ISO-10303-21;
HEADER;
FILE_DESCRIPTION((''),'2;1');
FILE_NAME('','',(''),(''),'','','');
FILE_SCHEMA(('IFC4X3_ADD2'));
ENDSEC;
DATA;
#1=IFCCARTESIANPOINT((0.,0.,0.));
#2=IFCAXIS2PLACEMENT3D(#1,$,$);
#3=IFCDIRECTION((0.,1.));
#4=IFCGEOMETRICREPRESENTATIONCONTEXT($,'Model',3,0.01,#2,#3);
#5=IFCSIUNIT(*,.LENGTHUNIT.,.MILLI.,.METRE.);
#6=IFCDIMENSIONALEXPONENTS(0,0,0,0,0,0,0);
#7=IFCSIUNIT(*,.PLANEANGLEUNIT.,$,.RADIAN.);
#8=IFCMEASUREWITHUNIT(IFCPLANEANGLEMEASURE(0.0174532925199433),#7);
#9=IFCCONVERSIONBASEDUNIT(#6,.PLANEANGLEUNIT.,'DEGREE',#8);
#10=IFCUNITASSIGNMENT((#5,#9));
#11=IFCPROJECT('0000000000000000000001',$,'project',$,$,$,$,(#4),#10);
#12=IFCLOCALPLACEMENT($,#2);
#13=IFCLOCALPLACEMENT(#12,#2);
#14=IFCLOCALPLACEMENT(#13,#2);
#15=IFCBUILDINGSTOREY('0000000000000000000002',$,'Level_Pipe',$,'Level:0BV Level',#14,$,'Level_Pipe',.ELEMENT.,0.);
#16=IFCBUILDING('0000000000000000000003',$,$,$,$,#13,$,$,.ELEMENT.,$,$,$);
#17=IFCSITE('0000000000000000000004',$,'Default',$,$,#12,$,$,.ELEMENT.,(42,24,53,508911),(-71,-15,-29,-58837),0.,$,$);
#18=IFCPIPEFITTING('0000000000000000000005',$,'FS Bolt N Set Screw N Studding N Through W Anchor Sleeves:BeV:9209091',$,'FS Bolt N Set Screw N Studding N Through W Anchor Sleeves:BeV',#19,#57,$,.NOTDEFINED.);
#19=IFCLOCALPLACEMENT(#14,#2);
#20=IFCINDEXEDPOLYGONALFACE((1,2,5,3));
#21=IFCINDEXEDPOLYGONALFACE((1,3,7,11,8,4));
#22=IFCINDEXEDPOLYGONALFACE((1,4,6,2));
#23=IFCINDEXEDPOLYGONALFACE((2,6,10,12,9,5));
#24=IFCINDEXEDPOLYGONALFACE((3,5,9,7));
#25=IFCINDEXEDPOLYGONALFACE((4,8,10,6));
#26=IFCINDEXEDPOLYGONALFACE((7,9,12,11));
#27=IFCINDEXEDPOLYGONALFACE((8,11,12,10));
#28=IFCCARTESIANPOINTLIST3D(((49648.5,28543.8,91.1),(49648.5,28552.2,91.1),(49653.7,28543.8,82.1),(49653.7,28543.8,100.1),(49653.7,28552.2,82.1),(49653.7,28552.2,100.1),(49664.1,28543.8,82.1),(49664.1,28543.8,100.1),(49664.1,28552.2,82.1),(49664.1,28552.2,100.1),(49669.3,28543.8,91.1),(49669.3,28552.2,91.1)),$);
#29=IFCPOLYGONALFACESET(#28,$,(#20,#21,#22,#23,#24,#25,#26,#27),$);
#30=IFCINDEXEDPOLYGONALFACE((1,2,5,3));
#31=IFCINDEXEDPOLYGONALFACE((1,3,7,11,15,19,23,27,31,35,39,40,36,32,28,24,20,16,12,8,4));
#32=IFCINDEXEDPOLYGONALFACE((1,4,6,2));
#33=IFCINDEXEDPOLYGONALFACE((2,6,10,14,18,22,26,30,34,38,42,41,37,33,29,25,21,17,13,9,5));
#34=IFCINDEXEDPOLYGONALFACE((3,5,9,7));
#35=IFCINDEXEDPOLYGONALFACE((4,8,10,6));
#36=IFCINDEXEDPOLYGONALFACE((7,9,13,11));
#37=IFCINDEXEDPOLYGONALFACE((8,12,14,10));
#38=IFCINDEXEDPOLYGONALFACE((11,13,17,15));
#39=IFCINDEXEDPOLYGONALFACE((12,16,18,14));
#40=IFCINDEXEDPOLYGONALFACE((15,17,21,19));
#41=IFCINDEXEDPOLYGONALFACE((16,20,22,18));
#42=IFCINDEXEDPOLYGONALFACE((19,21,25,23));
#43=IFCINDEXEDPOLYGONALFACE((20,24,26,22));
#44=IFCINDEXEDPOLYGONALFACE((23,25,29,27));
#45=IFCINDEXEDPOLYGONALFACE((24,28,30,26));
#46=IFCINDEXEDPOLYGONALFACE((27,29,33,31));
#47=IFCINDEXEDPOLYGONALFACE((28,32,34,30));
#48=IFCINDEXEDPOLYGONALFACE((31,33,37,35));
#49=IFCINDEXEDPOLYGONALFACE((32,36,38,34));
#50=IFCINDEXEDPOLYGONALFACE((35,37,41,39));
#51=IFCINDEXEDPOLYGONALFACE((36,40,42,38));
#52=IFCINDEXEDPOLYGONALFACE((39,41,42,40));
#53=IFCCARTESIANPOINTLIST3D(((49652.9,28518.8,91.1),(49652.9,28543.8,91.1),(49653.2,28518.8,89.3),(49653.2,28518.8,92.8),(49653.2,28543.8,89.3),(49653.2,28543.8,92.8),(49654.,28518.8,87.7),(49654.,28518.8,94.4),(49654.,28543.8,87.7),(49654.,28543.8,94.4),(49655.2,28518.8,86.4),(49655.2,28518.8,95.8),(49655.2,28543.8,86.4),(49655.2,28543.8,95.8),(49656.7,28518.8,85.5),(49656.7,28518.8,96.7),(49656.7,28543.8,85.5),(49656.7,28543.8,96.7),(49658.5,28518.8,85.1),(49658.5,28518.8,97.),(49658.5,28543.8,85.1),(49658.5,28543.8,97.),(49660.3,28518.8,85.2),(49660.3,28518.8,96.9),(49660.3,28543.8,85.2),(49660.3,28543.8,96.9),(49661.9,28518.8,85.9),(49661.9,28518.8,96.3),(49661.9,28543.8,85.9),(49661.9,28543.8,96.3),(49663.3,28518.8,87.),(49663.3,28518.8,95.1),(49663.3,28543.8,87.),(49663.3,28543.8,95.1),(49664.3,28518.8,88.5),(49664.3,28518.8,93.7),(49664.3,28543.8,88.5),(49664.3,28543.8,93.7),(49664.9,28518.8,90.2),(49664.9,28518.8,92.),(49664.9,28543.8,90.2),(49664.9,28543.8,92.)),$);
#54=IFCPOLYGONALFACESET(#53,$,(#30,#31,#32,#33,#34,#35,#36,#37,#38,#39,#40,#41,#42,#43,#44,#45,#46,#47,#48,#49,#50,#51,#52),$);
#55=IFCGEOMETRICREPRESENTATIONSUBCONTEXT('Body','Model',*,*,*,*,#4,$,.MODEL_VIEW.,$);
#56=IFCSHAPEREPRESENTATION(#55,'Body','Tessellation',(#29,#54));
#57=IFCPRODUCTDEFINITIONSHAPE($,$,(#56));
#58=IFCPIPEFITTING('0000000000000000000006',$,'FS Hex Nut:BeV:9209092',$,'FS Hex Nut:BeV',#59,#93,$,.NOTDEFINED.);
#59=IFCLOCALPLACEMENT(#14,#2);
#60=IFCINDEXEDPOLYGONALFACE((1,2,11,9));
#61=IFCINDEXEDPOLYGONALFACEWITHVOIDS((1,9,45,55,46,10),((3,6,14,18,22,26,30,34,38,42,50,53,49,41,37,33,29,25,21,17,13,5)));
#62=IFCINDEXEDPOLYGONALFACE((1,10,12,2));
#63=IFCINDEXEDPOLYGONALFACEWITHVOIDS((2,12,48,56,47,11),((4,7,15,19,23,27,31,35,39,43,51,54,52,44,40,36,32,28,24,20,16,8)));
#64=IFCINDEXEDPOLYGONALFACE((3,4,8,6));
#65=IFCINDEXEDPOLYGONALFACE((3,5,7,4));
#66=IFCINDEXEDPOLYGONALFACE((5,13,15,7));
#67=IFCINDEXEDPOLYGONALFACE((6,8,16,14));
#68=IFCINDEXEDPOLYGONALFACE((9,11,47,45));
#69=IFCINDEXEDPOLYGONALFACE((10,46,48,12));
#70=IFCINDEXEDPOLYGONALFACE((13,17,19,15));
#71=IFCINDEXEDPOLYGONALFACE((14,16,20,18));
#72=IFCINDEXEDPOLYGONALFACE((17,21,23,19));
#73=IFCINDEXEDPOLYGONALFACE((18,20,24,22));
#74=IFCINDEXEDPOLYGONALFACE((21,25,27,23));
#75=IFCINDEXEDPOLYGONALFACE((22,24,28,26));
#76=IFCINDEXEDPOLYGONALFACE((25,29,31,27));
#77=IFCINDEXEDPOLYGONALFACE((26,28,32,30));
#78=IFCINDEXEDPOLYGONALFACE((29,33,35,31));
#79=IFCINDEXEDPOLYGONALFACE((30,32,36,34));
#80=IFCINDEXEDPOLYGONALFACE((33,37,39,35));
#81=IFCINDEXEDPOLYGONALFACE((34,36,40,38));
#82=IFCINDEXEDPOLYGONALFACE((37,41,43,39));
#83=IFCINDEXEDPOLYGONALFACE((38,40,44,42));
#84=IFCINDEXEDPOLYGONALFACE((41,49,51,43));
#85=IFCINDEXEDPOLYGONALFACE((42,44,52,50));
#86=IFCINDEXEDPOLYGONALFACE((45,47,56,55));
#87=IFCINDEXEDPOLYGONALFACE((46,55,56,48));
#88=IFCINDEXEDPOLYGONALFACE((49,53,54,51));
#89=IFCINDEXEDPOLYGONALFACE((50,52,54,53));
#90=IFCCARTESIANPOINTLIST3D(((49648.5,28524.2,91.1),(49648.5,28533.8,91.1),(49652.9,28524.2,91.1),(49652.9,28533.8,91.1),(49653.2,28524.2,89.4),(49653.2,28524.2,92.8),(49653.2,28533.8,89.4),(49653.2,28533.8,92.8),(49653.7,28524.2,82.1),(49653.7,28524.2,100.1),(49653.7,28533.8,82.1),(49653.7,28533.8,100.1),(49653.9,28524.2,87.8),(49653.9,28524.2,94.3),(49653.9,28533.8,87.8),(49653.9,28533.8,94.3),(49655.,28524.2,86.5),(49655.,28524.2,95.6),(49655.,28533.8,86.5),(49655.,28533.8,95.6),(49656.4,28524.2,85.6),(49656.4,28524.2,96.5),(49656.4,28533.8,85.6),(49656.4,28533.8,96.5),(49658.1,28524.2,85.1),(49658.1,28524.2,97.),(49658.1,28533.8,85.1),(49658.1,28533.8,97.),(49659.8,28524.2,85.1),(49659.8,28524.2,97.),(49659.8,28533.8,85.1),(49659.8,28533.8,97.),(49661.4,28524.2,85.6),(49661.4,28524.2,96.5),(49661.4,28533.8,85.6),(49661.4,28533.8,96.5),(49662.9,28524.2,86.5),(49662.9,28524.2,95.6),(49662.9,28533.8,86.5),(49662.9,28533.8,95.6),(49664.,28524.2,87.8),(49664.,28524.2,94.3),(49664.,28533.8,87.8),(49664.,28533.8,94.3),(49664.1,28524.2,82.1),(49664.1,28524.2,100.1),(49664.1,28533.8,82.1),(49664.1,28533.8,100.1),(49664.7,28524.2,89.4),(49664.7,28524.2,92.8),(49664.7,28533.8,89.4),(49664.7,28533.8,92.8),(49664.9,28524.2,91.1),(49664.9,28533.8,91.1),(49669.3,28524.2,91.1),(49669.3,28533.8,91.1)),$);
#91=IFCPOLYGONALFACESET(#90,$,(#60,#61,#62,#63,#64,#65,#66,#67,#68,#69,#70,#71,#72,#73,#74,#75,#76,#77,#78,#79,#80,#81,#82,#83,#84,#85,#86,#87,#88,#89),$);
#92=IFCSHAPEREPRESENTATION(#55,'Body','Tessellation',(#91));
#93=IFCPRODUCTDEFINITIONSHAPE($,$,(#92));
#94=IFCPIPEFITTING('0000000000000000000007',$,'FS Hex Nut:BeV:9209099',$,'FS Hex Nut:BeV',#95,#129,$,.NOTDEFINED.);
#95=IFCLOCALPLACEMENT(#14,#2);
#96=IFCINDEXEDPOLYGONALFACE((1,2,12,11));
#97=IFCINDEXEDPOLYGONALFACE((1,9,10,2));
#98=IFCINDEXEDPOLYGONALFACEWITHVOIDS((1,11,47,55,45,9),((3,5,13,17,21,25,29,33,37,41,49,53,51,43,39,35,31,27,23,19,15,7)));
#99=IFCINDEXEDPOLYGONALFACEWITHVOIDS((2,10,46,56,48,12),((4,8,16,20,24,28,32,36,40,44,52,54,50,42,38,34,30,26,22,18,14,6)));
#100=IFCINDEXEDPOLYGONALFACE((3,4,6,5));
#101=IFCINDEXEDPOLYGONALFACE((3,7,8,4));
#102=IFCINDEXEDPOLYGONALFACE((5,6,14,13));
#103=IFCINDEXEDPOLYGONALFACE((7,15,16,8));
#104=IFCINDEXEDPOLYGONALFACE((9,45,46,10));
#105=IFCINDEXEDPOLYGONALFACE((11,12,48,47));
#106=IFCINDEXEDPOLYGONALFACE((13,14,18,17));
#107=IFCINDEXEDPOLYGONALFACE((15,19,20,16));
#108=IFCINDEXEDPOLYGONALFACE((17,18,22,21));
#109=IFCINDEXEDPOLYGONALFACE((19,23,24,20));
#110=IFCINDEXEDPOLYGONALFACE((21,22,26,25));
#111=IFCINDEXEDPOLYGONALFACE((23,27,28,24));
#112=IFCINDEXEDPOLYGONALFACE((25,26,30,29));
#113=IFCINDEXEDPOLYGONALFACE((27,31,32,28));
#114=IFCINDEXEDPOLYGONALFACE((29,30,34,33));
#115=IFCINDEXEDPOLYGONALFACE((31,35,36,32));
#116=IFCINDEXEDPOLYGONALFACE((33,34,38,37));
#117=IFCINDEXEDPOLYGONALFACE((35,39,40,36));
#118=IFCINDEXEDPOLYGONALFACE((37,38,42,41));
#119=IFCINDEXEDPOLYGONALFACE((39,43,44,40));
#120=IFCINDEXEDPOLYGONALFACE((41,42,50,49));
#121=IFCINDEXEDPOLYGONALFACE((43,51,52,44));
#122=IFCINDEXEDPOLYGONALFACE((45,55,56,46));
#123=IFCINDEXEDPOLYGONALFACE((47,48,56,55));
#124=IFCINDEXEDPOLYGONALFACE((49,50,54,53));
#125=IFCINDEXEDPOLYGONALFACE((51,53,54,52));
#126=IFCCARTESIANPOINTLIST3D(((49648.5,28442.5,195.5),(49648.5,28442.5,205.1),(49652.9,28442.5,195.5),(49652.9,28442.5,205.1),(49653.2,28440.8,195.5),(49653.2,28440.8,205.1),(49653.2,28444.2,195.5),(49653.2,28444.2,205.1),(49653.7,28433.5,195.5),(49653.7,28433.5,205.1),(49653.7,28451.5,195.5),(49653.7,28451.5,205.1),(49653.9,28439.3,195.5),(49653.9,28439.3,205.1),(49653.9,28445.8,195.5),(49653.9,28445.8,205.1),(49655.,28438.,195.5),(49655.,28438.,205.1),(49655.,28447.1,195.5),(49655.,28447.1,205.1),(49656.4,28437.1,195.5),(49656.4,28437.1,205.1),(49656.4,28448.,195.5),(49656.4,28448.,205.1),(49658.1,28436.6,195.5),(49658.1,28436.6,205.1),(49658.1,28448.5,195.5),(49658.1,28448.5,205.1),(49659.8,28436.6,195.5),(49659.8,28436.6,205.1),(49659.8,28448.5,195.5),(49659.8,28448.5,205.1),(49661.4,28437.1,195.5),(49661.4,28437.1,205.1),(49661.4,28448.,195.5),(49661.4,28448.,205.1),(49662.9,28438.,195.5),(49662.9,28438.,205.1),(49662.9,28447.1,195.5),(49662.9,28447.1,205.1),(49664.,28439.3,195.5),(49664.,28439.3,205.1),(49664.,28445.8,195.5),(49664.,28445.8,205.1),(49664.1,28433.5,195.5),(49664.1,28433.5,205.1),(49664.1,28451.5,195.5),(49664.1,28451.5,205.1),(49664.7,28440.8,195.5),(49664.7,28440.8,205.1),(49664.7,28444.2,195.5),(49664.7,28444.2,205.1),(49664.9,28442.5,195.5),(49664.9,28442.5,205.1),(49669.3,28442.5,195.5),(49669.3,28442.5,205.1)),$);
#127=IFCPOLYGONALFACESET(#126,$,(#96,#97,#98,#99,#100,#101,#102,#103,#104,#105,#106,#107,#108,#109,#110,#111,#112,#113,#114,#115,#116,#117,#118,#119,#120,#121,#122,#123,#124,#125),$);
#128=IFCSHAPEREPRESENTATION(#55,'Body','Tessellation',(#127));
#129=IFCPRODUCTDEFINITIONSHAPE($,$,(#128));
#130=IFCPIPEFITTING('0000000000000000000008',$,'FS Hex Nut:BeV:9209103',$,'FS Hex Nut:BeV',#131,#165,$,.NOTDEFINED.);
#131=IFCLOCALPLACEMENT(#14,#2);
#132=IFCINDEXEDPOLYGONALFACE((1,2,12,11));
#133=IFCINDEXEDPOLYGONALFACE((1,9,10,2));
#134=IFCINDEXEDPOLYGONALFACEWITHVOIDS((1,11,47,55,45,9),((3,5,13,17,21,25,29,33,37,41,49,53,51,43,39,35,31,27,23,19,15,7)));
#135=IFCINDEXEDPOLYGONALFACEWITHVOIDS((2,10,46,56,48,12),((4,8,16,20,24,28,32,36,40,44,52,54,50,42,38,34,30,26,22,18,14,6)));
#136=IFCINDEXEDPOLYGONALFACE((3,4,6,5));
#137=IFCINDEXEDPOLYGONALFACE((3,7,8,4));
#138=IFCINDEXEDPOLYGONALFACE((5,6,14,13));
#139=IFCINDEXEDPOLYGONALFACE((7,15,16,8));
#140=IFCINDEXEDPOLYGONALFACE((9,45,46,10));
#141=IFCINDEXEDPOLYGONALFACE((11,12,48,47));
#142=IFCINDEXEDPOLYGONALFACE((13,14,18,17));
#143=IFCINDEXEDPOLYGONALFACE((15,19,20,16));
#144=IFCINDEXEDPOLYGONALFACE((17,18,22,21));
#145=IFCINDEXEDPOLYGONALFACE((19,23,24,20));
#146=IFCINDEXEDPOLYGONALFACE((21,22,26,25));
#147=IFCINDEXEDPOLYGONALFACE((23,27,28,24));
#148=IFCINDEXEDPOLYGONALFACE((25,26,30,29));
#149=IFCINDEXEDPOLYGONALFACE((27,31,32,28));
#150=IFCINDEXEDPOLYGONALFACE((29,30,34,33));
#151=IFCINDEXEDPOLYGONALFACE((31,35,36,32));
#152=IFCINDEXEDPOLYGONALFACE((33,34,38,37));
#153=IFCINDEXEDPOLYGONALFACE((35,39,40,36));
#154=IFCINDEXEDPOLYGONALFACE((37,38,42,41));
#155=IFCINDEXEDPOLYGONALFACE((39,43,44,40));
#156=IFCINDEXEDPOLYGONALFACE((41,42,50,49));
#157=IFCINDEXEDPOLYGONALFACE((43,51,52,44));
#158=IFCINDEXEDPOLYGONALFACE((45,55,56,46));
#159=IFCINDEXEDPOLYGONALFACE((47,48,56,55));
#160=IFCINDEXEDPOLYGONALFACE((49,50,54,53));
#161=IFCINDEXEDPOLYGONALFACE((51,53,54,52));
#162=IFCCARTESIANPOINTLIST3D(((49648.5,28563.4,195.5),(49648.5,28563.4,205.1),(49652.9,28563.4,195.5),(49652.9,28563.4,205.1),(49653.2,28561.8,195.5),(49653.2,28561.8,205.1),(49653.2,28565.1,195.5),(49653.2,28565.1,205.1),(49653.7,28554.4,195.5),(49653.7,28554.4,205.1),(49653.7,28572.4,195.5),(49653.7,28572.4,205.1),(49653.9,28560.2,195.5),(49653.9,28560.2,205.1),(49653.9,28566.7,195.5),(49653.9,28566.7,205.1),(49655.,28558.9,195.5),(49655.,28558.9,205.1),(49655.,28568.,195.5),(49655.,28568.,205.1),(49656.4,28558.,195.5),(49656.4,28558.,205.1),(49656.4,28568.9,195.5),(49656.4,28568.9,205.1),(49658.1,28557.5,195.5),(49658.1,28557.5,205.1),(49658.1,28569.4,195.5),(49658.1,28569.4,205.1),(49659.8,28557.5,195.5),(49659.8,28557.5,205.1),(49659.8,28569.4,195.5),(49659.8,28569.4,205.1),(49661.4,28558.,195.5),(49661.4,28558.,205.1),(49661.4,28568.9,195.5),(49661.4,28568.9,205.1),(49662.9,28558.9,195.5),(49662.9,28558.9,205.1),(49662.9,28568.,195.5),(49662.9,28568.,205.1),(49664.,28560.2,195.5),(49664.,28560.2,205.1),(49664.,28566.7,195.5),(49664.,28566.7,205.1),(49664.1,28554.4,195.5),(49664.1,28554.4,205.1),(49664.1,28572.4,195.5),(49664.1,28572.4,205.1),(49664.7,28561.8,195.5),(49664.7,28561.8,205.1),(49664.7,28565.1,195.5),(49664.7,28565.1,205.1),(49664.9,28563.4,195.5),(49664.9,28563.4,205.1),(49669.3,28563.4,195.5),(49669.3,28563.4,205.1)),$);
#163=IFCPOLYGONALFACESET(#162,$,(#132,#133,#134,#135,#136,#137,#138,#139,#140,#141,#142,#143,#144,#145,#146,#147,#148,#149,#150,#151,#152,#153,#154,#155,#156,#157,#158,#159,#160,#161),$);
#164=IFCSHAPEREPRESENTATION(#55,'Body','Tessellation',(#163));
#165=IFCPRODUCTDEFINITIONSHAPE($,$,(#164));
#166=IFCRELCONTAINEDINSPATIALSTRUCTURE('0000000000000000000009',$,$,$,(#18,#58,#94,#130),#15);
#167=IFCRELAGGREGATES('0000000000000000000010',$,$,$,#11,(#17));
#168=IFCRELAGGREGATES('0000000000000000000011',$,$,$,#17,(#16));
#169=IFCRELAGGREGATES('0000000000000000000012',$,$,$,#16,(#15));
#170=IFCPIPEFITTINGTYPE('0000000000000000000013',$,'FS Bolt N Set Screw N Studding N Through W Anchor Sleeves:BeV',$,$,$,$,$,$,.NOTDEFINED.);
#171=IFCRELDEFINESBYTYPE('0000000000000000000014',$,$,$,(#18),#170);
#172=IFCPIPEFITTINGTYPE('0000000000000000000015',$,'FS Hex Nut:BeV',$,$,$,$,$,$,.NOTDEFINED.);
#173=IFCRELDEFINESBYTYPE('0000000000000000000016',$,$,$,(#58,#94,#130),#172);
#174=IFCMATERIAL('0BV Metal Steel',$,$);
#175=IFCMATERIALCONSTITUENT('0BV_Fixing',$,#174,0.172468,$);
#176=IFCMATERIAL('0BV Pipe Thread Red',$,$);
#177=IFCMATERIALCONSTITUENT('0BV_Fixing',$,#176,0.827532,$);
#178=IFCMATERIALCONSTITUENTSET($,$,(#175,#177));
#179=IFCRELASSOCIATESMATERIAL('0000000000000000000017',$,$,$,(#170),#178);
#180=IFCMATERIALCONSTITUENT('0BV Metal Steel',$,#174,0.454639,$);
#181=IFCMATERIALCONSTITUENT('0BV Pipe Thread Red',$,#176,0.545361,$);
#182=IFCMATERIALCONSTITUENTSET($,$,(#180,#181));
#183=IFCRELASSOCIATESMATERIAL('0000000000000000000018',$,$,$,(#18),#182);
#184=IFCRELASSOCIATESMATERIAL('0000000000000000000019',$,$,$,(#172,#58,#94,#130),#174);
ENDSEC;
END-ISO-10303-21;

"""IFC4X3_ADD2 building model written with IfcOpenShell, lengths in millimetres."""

from ifc_helpers import new_model, entity, si_unit, converted_unit, direction, frame, frame_2d, origin, origin_2d_with_axis, place, context, subcontext, project, spatial, polyline, circle_curve, parameter, trimmed, segment, composite_curve, circle, outline, extrude, source, transform, mapped, material, constituent, constituent_set, type_object, type_shapes, element, save


model = new_model("IFC4X3_ADD2")

# Units and contexts
model_context = context("Model", 3, precision=0.01, world=origin(), true_north=direction((0.0, 1.0)))
body_context = subcontext(model_context, "Body", "Model", "MODEL_VIEW")
ifc_project = project(units=[si_unit("LENGTHUNIT", "METRE", prefix="MILLI"), converted_unit("PLANEANGLEUNIT", "DEGREE", entity("IfcPlaneAngleMeasure", 0.0174532925199433), si_unit("PLANEANGLEUNIT", "RADIAN"), dimensions=[0, 0, 0, 0, 0, 0, 0])], contexts=[model_context])

# Site, building, storey
site_placement = place(None, origin())
site = spatial("IfcSite", under=ifc_project, at=site_placement, Name="Default", CompositionType="ELEMENT", RefLatitude=(42, 24, 53, 508911), RefLongitude=(-71, -15, -29, -58837), RefElevation=0.0)
building_placement = place(site_placement, origin())
building = spatial("IfcBuilding", under=site, at=building_placement, CompositionType="ELEMENT")
storey_placement = place(building_placement, origin())
storey = spatial("IfcBuildingStorey", under=building, at=storey_placement, Name="Level_Pipe", ObjectType="Level:0BV Level", LongName="Level_Pipe", CompositionType="ELEMENT", Elevation=0.0)

# Pipe fittings
ifc_material_1 = material(Name="0BV Metal Steel")
ifc_constituent_1 = constituent(ifc_material_1, Name="0BV Metal Steel", fraction=0.454639)
ifc_material_2 = material(Name="0BV Pipe Thread Red")
ifc_constituent_2 = constituent(ifc_material_2, Name="0BV Pipe Thread Red", fraction=0.545361)
ifc_constituent_set_1 = constituent_set(constituents=[ifc_constituent_1, ifc_constituent_2])
ifc_constituent_3 = constituent(ifc_material_1, Name="0BV_Fixing", fraction=0.172468)
ifc_constituent_4 = constituent(ifc_material_2, Name="0BV_Fixing", fraction=0.827532)
ifc_constituent_set_2 = constituent_set(constituents=[ifc_constituent_3, ifc_constituent_4])
pipe_fitting_type_1 = type_object("IfcPipeFittingType", Name="FS Bolt N Set Screw N Studding N Through W Anchor Sleeves:BeV", PredefinedType="NOTDEFINED", material=ifc_constituent_set_2)
shared_shape_1 = source(origin(), body_context, "Body", "SweptSolid", [
    extrude(outline(polyline([(-5.2, -9.0), (5.2, -9.0), (10.4, 0.0), (5.2, 9.0), (-5.2, 9.0), (-10.4, 0.0), (-5.2, -9.0)])), frame((-8.4, 0.0, 0.0), z_axis=(1.0, 0.0, 0.0), x_axis=(0.0, -1.0, 0.0)), (0.0, 0.0, 1.0), 8.4),
    extrude(circle(Radius=6.0, at=frame_2d((0.0, 0.0), x_axis=(1.0, 0.0))), frame((0.0, 0.0, 0.0), z_axis=(1.0, 0.0, 0.0), x_axis=(0.0, -1.0, 0.0)), (0.0, 0.0, 1.0), 25.0),
])
type_shapes(pipe_fitting_type_1, [shared_shape_1])
pipe_fitting_1_placement = place(storey_placement, frame((49658.9, 28543.8, 91.1), z_axis=(0.0, 0.0, 1.0), x_axis=(0.0, -1.0, 0.0)))
element("IfcPipeFitting", 1, at=pipe_fitting_1_placement, inside=storey, type_object=pipe_fitting_type_1, material=ifc_constituent_set_1, Name="FS Bolt N Set Screw N Studding N Through W Anchor Sleeves:BeV:9209091", ObjectType="FS Bolt N Set Screw N Studding N Through W Anchor Sleeves:BeV", PredefinedType="NOTDEFINED", context=body_context, shape_type="MappedRepresentation", body=[
    mapped(shared_shape_1, transform((0.0, 0.0, 0.0), scale=1.0)),
])
pipe_fitting_type_2 = type_object("IfcPipeFittingType", Name="FS Hex Nut:BeV", PredefinedType="NOTDEFINED", material=ifc_material_1)
shared_shape_2 = source(origin(), body_context, "Body", "SweptSolid", [
    extrude(outline(polyline([(-5.2, -9.0), (5.2, -9.0), (10.4, 0.0), (5.2, 9.0), (-5.2, 9.0), (-10.4, 0.0), (-5.2, -9.0)]), holes=[composite_curve([segment(trimmed(circle_curve(origin_2d_with_axis(), 6.0), [parameter(0.0)], [parameter(180.0)], True, "PARAMETER"), False, "CONTINUOUS"), segment(trimmed(circle_curve(origin_2d_with_axis(), 6.0), [parameter(180.0)], [parameter(0.0)], True, "PARAMETER"), False, "CONTINUOUS")], self_intersect=False)]), frame((0.0, 10.4, 9.0), z_axis=(1.0, 0.0, 0.0), x_axis=(0.0, -1.0, 0.0)), (0.0, 0.0, 1.0), 9.6),
])
type_shapes(pipe_fitting_type_2, [shared_shape_2])
for number, where, z_axis, x_axis, name in (
    (2, (49648.5, 28533.8, 82.1), (0.0, 0.0, 1.0), (0.0, -1.0, 0.0), "FS Hex Nut:BeV:9209092"),
    (3, (49648.5, 28451.5, 205.1), (0.0, -1.0, 0.0), (0.0, 0.0, -1.0), "FS Hex Nut:BeV:9209099"),
    (4, (49648.5, 28572.4, 205.1), (0.0, -1.0, 0.0), (0.0, 0.0, -1.0), "FS Hex Nut:BeV:9209103"),
):
    element("IfcPipeFitting", number, at=place(storey_placement, frame(where, z_axis=z_axis, x_axis=x_axis)), inside=storey, type_object=pipe_fitting_type_2, material=ifc_material_1, Name=name, ObjectType="FS Hex Nut:BeV", PredefinedType="NOTDEFINED", context=body_context, shape_type="MappedRepresentation", body=[
        mapped(shared_shape_2, transform((0.0, 0.0, 0.0), scale=1.0)),
    ])

save(model, "model.ifc")
